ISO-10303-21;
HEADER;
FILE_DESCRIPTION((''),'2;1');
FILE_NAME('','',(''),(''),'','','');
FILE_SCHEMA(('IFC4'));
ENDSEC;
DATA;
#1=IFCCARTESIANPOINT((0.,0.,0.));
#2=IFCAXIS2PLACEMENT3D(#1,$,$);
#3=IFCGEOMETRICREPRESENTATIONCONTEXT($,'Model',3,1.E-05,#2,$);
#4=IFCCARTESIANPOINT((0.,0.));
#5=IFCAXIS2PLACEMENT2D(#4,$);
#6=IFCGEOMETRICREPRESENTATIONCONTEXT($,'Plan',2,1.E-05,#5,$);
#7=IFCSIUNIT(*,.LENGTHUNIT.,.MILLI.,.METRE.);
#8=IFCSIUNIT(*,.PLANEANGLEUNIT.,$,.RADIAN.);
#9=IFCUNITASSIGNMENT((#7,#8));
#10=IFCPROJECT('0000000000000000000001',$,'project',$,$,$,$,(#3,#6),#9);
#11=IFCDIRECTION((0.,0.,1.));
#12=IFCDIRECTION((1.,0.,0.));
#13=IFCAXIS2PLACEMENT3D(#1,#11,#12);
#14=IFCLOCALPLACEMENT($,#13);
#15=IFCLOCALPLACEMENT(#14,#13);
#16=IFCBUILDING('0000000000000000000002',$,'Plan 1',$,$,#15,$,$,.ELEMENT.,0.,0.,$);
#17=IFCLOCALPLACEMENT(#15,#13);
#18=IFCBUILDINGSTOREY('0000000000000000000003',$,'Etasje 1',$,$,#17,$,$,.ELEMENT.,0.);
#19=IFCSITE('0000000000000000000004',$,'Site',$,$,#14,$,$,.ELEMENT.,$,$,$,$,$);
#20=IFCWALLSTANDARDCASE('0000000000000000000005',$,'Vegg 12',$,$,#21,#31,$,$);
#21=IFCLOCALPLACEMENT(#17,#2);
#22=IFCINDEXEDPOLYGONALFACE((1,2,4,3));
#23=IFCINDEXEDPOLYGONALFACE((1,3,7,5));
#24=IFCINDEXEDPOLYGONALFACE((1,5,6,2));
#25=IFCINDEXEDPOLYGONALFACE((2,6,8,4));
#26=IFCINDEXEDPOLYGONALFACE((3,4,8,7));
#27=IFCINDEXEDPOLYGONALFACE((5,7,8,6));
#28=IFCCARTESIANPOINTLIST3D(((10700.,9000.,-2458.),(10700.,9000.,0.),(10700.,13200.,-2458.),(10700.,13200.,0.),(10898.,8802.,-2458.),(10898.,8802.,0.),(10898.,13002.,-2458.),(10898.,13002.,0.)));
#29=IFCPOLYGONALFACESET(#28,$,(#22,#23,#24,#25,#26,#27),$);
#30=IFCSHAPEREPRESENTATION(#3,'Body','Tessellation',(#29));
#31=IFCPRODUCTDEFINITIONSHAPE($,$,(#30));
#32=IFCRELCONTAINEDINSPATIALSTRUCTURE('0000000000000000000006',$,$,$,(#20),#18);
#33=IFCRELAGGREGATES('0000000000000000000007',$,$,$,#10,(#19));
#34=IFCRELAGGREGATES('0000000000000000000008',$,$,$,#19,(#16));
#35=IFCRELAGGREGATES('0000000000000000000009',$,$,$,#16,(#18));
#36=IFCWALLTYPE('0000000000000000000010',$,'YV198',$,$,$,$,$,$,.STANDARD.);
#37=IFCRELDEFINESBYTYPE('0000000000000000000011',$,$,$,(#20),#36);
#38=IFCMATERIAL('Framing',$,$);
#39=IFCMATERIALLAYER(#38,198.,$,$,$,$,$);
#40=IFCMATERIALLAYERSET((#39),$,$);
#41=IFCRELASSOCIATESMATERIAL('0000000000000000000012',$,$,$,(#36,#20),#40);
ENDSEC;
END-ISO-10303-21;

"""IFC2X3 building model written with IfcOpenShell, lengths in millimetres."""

from ifc_helpers import new_model, si_unit, frame, origin, origin_with_axes, origin_2d, place, context, project, spatial, polyline, segment, composite_curve, outline, extrude, material, layer, layer_set, layer_usage, type_object, element, save


model = new_model("IFC2X3")

# Units and contexts
model_context = context("Model", 3, precision=1e-05, world=origin())
plan_context = context("Plan", 2, precision=1e-05, world=origin_2d())
ifc_project = project(units=[si_unit("LENGTHUNIT", "METRE", prefix="MILLI"), si_unit("PLANEANGLEUNIT", "RADIAN")], contexts=[model_context, plan_context])

# Site, building, storey
site_placement = place(None, origin_with_axes())
site = spatial("IfcSite", under=ifc_project, at=site_placement, Name="Site", CompositionType="ELEMENT")
building_placement = place(site_placement, origin_with_axes())
building = spatial("IfcBuilding", under=site, at=building_placement, Name="Plan 1", CompositionType="ELEMENT", ElevationOfRefHeight=0.0, ElevationOfTerrain=0.0)
storey_placement = place(building_placement, origin_with_axes())
storey = spatial("IfcBuildingStorey", under=building, at=storey_placement, Name="Etasje 1", CompositionType="ELEMENT", Elevation=0.0)

# Wall
ifc_material = material(Name="Framing")
ifc_layer = layer(ifc_material, 198.0)
ifc_layer_set = layer_set([ifc_layer])
wall_type = type_object("IfcWallType", Name="YV198", PredefinedType="STANDARD", material=ifc_layer_set)
ifc_layer_usage_1 = layer_usage(ifc_layer_set, "AXIS2", "POSITIVE", 0.0)
wall_1_placement = place(storey_placement, frame((10700.0, 13200.0, -2458.0), z_axis=(0.0, 0.0, 1.0), x_axis=(0.0, -1.0, 0.0)))
element("IfcWallStandardCase", 1, at=wall_1_placement, inside=storey, type_object=wall_type, material=ifc_layer_usage_1, Name="Vegg 12", context=model_context, shape_type="SweptSolid", body=[
    extrude(outline(composite_curve([segment(polyline([(198.0, 198.0), (0.0, 0.0)]), True, "CONTINUOUS"), segment(polyline([(0.0, 0.0), (4200.0, 0.0)]), True, "CONTINUOUS"), segment(polyline([(4200.0, 0.0), (4398.0, 198.0)]), True, "CONTINUOUS"), segment(polyline([(4398.0, 198.0), (198.0, 198.0)]), True, "CONTINUOUS")], self_intersect=False)), origin_with_axes(), (0.0, 0.0, 1.0), 2458.0),
])

save(model, "model.ifc")
